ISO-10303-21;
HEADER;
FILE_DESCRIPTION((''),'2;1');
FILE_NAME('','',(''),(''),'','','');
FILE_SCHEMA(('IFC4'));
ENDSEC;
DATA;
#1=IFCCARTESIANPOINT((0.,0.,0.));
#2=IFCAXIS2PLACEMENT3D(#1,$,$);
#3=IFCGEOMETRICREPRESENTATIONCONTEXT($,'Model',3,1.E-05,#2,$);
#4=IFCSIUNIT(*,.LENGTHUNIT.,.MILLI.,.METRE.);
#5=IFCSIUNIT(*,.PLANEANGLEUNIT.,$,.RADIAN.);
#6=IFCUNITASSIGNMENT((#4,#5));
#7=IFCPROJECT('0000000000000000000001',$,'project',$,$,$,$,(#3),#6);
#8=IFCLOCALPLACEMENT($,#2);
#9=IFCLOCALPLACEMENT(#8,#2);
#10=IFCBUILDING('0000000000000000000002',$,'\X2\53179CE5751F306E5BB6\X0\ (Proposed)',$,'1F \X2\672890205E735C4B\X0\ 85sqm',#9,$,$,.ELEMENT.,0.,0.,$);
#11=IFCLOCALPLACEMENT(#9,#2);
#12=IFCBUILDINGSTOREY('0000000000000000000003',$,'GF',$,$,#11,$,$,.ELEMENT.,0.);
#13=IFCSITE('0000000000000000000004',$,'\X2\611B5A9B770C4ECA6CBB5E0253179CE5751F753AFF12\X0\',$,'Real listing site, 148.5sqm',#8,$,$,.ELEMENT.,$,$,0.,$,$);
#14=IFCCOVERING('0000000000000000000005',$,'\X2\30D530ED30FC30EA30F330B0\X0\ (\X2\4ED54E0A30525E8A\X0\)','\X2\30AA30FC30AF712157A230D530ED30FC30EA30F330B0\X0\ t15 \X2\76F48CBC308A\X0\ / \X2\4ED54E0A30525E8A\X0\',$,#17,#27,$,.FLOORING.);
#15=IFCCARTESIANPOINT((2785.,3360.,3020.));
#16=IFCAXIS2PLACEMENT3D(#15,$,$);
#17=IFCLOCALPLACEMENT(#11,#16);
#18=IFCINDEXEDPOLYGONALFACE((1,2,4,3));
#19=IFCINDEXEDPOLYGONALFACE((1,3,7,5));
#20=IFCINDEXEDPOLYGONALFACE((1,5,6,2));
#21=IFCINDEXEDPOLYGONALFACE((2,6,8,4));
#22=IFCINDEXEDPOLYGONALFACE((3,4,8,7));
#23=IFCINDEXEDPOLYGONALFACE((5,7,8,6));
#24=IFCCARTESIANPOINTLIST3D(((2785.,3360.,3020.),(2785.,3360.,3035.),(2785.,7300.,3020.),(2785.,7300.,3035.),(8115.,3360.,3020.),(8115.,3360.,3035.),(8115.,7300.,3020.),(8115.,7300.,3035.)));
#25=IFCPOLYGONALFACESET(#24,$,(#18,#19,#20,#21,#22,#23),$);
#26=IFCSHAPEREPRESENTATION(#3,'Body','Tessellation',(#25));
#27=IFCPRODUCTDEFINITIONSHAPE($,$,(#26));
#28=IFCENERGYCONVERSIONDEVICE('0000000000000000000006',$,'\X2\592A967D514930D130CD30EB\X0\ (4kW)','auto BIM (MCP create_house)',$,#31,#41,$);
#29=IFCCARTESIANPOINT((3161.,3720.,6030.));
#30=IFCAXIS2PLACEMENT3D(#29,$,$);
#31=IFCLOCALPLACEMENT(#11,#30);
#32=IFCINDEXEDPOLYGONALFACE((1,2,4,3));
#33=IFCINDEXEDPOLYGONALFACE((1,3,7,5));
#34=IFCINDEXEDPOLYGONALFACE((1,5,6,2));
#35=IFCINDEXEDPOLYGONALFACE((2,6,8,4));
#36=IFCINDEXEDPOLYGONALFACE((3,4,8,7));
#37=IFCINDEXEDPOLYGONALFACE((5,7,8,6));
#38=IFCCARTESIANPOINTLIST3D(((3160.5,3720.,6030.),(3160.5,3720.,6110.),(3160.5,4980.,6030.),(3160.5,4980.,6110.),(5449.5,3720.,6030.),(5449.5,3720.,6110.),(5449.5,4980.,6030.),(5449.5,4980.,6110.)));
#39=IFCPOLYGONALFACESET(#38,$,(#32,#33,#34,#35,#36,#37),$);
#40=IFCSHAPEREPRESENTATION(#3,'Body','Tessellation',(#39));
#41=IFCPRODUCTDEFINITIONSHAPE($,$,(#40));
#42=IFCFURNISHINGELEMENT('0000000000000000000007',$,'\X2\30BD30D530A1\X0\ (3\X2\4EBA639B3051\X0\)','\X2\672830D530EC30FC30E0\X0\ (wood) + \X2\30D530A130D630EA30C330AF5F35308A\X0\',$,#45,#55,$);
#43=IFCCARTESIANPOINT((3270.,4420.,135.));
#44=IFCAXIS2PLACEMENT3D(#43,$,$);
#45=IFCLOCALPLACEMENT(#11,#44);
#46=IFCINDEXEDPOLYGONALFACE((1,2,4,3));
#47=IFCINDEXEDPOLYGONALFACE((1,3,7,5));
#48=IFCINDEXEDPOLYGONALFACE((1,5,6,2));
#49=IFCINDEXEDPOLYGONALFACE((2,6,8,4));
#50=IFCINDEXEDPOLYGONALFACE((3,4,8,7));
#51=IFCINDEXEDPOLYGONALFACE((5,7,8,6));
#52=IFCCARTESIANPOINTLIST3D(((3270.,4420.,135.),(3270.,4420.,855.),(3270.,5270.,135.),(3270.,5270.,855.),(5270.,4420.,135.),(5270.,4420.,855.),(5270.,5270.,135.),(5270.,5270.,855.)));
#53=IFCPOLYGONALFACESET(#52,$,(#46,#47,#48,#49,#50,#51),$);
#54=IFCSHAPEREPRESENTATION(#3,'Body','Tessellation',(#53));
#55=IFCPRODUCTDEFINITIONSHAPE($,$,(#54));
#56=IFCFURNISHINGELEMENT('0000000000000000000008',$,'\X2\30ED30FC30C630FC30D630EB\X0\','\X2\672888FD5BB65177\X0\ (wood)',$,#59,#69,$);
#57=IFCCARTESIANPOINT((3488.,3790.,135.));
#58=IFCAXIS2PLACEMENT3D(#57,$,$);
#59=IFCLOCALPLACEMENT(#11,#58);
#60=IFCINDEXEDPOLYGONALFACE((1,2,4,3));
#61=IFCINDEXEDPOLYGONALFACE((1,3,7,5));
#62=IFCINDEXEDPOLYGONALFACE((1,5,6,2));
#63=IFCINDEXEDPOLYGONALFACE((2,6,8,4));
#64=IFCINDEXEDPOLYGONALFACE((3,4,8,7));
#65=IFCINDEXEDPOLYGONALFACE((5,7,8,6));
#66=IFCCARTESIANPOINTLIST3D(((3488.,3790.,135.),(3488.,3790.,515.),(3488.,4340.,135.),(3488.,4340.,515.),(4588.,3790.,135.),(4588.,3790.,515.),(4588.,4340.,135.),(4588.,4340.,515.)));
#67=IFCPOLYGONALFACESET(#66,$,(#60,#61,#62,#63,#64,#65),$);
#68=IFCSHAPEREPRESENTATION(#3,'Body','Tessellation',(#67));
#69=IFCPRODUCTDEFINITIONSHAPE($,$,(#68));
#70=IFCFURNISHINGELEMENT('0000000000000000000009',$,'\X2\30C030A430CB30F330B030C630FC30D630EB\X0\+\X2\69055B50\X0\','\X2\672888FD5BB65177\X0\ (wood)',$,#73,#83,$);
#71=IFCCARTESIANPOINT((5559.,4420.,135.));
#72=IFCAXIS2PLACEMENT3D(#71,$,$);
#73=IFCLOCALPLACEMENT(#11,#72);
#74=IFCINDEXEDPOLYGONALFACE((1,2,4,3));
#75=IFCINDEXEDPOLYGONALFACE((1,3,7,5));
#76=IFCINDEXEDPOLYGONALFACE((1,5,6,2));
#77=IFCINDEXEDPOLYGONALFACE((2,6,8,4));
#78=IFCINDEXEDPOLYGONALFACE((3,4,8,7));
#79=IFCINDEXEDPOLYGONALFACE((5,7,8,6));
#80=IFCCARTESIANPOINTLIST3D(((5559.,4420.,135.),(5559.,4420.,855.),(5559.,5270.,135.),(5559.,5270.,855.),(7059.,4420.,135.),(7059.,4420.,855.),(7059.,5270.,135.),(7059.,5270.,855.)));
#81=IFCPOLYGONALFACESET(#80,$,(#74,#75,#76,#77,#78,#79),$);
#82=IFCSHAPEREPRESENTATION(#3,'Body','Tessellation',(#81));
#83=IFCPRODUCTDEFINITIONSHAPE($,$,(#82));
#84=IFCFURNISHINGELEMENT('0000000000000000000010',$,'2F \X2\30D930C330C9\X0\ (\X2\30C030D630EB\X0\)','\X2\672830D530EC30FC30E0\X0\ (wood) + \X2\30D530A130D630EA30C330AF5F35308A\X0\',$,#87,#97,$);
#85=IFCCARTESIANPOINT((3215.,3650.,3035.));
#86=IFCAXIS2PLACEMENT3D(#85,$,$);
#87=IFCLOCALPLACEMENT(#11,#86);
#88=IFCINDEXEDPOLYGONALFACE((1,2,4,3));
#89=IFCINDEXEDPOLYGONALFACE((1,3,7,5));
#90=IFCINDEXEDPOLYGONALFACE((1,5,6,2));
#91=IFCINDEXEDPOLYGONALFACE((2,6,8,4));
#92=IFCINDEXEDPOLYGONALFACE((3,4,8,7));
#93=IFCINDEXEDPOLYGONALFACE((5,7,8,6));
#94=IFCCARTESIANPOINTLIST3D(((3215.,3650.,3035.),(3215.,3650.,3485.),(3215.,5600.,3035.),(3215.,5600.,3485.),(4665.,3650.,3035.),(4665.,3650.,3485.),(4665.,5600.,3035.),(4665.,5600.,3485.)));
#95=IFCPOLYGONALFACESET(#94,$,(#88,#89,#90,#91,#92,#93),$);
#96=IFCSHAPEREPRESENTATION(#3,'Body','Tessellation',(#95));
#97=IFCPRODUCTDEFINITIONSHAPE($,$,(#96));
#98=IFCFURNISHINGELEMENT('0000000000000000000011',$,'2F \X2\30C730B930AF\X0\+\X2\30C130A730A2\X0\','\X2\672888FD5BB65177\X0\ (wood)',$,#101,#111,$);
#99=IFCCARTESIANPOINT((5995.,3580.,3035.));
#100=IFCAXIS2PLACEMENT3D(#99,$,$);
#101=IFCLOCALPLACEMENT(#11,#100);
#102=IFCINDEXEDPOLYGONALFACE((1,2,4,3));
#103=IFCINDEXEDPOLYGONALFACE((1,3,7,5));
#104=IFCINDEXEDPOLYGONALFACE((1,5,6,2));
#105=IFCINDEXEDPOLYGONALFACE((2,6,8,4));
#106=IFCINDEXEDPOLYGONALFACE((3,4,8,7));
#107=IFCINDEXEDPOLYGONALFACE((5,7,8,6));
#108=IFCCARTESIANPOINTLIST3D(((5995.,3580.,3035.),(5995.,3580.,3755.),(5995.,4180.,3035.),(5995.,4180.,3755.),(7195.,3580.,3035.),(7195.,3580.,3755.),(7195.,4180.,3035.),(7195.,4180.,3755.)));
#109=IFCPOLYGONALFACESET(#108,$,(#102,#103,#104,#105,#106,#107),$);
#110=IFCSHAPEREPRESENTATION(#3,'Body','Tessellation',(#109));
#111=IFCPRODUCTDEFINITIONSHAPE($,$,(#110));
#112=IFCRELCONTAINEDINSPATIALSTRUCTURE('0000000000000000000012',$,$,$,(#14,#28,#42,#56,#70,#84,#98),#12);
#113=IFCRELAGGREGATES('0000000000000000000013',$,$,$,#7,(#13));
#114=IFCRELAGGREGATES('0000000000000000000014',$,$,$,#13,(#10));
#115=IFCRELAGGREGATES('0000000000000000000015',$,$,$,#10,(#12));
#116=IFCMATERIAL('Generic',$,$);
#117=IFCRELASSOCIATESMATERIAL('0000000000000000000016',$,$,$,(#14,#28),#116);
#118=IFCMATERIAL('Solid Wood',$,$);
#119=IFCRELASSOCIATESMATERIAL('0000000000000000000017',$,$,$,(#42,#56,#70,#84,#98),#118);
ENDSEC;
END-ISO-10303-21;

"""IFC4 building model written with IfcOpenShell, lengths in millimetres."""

from ifc_helpers import new_model, si_unit, frame, frame_2d, origin, place, context, project, spatial, rectangle, extrude, material, element, save


model = new_model("IFC4")

# Units and contexts
model_context = context("Model", 3, precision=1e-05, world=origin())
ifc_project = project(units=[si_unit("LENGTHUNIT", "METRE", prefix="MILLI"), si_unit("PLANEANGLEUNIT", "RADIAN")], contexts=[model_context])

# Site, building, storey
site_placement = place(None, origin())
site = spatial("IfcSite", under=ifc_project, at=site_placement, Name="愛媛県今治市北鳥生町２", ObjectType="Real listing site, 148.5sqm", CompositionType="ELEMENT", RefElevation=0.0)
building_placement = place(site_placement, origin())
building = spatial("IfcBuilding", under=site, at=building_placement, Name="北鳥生の家 (Proposed)", ObjectType="1F 木造平屋 85sqm", CompositionType="ELEMENT", ElevationOfRefHeight=0.0, ElevationOfTerrain=0.0)
storey_placement = place(building_placement, origin())
storey = spatial("IfcBuildingStorey", under=building, at=storey_placement, Name="GF", CompositionType="ELEMENT", Elevation=0.0)

# Shared definitions
ifc_material_1 = material(Name="Solid Wood")

# Shared definitions
ifc_material_2 = material(Name="Generic")

# Covering
covering_placement = place(storey_placement, frame((2785.0, 3360.0, 3020.0)))
element("IfcCovering", 1, at=covering_placement, inside=storey, material=ifc_material_2, Name="フローリング (仕上げ床)", Description="オーク無垢フローリング t15 直貼り / 仕上げ床", PredefinedType="FLOORING", context=model_context, shape_type="SweptSolid", body=[
    extrude(rectangle(XDim=5330.0, YDim=3940.0, at=frame_2d((2665.0, 1970.0))), frame((2785.0, 3360.0, 3020.0)), (0.0, 0.0, 1.0), 15.0),
])

# Energy conversion device
energy_conversion_device_placement = place(storey_placement, frame((3161.0, 3720.0, 6030.0)))
element("IfcEnergyConversionDevice", 2, at=energy_conversion_device_placement, inside=storey, material=ifc_material_2, Name="太陽光パネル (4kW)", Description="auto BIM (MCP create_house)", context=model_context, shape_type="SweptSolid", body=[
    extrude(rectangle(XDim=2289.0, YDim=1260.0, at=frame_2d((1144.0, 630.0))), frame((3161.0, 3720.0, 6030.0)), (0.0, 0.0, 1.0), 80.0),
])

# Furnishing elements
furnishing_1_placement = place(storey_placement, frame((3270.0, 4420.0, 135.0)))
element("IfcFurnishingElement", 3, at=furnishing_1_placement, inside=storey, material=ifc_material_1, Name="ソファ (3人掛け)", Description="木フレーム (wood) + ファブリック張り", context=model_context, shape_type="SweptSolid", body=[
    extrude(rectangle(XDim=2000.0, YDim=850.0, at=frame_2d((1000.0, 425.0))), frame((3270.0, 4420.0, 135.0)), (0.0, 0.0, 1.0), 720.0),
])
furnishing_2_placement = place(storey_placement, frame((3488.0, 3790.0, 135.0)))
element("IfcFurnishingElement", 4, at=furnishing_2_placement, inside=storey, material=ifc_material_1, Name="ローテーブル", Description="木製家具 (wood)", context=model_context, shape_type="SweptSolid", body=[
    extrude(rectangle(XDim=1100.0, YDim=550.0, at=frame_2d((550.0, 275.0))), frame((3488.0, 3790.0, 135.0)), (0.0, 0.0, 1.0), 380.0),
])
furnishing_3_placement = place(storey_placement, frame((5559.0, 4420.0, 135.0)))
element("IfcFurnishingElement", 5, at=furnishing_3_placement, inside=storey, material=ifc_material_1, Name="ダイニングテーブル+椅子", Description="木製家具 (wood)", context=model_context, shape_type="SweptSolid", body=[
    extrude(rectangle(XDim=1500.0, YDim=850.0, at=frame_2d((750.0, 425.0))), frame((5559.0, 4420.0, 135.0)), (0.0, 0.0, 1.0), 720.0),
])
furnishing_4_placement = place(storey_placement, frame((3215.0, 3650.0, 3035.0)))
element("IfcFurnishingElement", 6, at=furnishing_4_placement, inside=storey, material=ifc_material_1, Name="2F ベッド (ダブル)", Description="木フレーム (wood) + ファブリック張り", context=model_context, shape_type="SweptSolid", body=[
    extrude(rectangle(XDim=1450.0, YDim=1950.0, at=frame_2d((725.0, 975.0))), frame((3215.0, 3650.0, 3035.0)), (0.0, 0.0, 1.0), 450.0),
])
furnishing_5_placement = place(storey_placement, frame((5995.0, 3580.0, 3035.0)))
element("IfcFurnishingElement", 7, at=furnishing_5_placement, inside=storey, material=ifc_material_1, Name="2F デスク+チェア", Description="木製家具 (wood)", context=model_context, shape_type="SweptSolid", body=[
    extrude(rectangle(XDim=1200.0, YDim=600.0, at=frame_2d((600.0, 300.0))), frame((5995.0, 3580.0, 3035.0)), (0.0, 0.0, 1.0), 720.0),
])

save(model, "model.ifc")
